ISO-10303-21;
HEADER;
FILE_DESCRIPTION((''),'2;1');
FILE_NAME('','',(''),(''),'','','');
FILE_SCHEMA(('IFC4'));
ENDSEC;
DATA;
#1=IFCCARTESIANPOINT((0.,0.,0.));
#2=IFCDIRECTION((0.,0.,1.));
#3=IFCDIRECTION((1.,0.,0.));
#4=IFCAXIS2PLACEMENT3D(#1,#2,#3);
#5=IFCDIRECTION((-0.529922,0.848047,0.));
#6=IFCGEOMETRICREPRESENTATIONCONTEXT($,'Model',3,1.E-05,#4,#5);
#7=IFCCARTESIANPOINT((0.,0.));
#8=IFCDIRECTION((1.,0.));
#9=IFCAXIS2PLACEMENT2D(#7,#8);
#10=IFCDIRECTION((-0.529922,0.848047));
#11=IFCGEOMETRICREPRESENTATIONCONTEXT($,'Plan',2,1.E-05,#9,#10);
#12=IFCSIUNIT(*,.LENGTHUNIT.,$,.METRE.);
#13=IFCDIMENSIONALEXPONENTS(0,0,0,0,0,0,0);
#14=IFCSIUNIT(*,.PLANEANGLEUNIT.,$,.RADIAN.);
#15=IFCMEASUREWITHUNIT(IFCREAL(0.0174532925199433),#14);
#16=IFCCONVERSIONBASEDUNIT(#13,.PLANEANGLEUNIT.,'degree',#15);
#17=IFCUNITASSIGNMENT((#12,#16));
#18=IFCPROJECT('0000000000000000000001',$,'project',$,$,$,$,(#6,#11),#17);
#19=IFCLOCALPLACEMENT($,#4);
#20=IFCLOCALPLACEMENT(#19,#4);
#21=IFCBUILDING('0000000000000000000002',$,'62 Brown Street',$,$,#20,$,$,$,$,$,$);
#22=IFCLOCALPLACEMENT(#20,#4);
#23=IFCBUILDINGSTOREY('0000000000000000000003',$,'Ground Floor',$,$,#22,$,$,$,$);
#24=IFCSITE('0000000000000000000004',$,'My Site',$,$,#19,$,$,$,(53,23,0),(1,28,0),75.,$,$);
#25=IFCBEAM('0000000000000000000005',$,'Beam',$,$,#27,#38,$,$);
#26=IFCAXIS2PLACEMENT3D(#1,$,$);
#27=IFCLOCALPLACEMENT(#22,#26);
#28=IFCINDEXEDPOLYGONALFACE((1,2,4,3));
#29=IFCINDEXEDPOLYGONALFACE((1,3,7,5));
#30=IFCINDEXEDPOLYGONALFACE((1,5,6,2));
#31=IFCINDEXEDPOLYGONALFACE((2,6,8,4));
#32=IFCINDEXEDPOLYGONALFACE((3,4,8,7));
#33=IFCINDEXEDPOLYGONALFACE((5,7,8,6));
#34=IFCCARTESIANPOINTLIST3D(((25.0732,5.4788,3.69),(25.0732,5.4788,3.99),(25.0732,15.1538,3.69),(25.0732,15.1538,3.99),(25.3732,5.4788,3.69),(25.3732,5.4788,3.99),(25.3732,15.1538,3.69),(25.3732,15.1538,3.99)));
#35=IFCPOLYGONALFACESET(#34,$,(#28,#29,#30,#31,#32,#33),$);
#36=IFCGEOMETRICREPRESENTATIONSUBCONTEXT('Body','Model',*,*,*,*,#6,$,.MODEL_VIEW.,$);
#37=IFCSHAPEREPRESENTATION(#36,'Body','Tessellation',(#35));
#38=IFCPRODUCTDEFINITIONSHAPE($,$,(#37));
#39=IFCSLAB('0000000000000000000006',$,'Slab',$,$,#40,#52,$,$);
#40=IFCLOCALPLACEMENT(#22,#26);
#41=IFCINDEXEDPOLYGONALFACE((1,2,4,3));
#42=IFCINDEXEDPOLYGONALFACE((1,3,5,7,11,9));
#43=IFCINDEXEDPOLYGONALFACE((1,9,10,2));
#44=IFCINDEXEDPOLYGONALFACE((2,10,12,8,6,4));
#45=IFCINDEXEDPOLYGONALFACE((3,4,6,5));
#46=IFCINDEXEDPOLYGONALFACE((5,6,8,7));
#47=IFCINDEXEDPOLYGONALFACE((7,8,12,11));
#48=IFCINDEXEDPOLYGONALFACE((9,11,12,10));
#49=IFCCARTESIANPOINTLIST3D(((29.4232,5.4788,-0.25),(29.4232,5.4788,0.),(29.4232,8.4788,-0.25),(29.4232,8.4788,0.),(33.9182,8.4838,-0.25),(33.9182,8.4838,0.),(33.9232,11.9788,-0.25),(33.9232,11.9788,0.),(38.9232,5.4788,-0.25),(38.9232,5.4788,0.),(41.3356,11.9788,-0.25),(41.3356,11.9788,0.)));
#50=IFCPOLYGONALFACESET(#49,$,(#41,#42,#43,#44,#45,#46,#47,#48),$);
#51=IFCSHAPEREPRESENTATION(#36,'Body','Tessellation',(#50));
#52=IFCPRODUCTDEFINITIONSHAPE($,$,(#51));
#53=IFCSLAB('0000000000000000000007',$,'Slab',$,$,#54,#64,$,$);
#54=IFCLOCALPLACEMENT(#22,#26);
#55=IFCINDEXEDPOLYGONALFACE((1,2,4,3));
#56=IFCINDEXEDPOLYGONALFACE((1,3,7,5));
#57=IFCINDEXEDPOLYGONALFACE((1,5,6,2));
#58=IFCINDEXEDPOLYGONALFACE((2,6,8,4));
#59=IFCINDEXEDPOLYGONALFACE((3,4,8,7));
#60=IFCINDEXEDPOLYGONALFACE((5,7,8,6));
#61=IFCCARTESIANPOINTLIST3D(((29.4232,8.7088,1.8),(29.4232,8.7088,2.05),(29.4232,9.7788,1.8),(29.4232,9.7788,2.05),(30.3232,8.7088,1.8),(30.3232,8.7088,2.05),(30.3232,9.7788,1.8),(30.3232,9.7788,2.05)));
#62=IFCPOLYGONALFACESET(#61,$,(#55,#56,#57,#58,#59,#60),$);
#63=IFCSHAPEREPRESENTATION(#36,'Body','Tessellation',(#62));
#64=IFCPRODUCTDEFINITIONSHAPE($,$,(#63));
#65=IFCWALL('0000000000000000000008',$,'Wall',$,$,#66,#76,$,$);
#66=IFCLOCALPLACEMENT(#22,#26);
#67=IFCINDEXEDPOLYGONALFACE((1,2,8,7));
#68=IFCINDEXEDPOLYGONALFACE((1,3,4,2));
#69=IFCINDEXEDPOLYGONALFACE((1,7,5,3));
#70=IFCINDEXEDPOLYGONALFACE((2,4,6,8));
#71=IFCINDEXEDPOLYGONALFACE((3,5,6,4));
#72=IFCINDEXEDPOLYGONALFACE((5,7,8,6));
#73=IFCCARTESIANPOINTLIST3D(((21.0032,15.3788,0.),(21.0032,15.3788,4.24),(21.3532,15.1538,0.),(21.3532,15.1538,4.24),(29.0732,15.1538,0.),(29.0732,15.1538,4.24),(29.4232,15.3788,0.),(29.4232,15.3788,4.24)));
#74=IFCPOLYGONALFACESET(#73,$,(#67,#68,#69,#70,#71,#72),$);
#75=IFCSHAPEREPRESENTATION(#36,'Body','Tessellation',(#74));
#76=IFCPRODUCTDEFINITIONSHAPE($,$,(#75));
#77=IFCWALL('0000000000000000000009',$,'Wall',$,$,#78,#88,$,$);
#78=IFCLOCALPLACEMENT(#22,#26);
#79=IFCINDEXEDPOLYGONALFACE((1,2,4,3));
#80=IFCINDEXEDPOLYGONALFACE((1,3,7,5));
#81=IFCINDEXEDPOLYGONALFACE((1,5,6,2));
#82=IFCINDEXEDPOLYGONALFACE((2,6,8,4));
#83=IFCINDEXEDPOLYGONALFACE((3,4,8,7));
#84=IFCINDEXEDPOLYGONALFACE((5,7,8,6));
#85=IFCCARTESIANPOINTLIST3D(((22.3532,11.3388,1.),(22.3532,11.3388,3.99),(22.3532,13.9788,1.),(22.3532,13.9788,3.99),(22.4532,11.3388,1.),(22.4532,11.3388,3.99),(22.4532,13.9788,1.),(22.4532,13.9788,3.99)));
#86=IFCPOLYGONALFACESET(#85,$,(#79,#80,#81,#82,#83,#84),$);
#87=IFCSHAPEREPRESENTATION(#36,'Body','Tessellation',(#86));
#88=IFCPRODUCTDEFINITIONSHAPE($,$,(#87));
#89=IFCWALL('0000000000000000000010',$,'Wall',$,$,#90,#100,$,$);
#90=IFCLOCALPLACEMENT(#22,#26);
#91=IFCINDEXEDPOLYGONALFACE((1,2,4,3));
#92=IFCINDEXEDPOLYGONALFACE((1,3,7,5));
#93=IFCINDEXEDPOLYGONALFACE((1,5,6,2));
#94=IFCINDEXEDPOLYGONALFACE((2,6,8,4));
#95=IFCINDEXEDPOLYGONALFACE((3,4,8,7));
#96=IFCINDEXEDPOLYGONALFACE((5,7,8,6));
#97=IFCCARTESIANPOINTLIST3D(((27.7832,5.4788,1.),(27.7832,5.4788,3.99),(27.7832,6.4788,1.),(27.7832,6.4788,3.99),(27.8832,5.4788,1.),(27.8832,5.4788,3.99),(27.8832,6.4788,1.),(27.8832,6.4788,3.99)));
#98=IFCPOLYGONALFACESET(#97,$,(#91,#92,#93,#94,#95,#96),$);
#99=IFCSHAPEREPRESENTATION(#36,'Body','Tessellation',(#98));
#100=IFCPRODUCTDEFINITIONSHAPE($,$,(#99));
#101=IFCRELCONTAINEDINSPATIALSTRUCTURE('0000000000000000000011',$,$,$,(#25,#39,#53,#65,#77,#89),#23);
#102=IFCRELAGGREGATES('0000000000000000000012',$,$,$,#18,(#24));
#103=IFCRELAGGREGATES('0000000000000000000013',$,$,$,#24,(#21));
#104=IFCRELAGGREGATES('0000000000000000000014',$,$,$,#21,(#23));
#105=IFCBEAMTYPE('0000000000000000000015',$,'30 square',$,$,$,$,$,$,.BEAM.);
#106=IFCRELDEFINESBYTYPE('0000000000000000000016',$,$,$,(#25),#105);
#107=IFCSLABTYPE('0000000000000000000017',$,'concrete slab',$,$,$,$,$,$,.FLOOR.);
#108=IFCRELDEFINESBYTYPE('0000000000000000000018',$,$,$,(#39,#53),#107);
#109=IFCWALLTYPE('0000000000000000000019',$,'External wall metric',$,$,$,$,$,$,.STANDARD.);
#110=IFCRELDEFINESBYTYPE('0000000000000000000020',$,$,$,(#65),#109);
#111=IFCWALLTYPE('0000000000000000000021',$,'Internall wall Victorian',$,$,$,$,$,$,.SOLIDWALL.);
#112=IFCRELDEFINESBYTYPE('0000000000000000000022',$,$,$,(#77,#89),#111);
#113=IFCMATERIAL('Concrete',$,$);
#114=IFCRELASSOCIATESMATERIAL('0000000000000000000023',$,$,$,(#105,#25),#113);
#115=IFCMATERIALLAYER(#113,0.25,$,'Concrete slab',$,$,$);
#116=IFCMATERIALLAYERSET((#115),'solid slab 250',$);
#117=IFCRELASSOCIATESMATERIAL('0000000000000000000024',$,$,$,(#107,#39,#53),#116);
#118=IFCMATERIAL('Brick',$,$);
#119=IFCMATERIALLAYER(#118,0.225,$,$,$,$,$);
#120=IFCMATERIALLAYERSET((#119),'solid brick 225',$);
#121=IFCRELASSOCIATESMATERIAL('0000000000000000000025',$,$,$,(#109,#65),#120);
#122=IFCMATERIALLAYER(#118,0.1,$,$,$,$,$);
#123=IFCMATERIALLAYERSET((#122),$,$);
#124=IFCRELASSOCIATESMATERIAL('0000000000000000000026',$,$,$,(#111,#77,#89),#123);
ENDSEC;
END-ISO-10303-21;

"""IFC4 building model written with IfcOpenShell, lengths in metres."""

from ifc_helpers import new_model, entity, si_unit, converted_unit, direction, frame, origin_with_axes, origin_2d_with_axis, place, context, subcontext, project, spatial, line, indexed_curve, rectangle, outline, extrude, clip, halfspace, material, layer, layer_set, layer_usage, material_profile, profile_set, profile_usage, type_object, element, save


model = new_model("IFC4")

# Units and contexts
model_context = context("Model", 3, precision=1e-05, world=origin_with_axes(), true_north=direction((-0.529922, 0.848047, 0.0)))
plan_context = context("Plan", 2, precision=1e-05, world=origin_2d_with_axis(), true_north=direction((-0.529922, 0.848047)))
body_context_1 = subcontext(model_context, "Body", "Model", "MODEL_VIEW")
ifc_project = project(units=[si_unit("LENGTHUNIT", "METRE"), converted_unit("PLANEANGLEUNIT", "degree", entity("IfcReal", 0.0174532925199433), si_unit("PLANEANGLEUNIT", "RADIAN"), dimensions=[0, 0, 0, 0, 0, 0, 0])], contexts=[model_context, plan_context])

# Site, building, storey
site_placement = place(None, origin_with_axes())
site = spatial("IfcSite", under=ifc_project, at=site_placement, Name="My Site", RefLatitude=(53, 23, 0), RefLongitude=(1, 28, 0), RefElevation=75.0)
building_placement = place(site_placement, origin_with_axes())
building = spatial("IfcBuilding", under=site, at=building_placement, Name="62 Brown Street")
storey_placement = place(building_placement, origin_with_axes())
storey = spatial("IfcBuildingStorey", under=building, at=storey_placement, Name="Ground Floor")

# Shared definitions
ifc_material_1 = material(Name="Concrete")

# Beam
ifc_material_profile_1 = material_profile(ifc_material_1, rectangle(XDim=0.3, YDim=0.3))
ifc_profile_set_1 = profile_set([ifc_material_profile_1])
ifc_profile_usage_1 = profile_usage(ifc_profile_set_1, cardinal=5)
beam_type = type_object("IfcBeamType", Name="30 square", PredefinedType="BEAM", material=ifc_profile_set_1)
beam_placement = place(storey_placement, frame((25.2232, 5.4788, 3.84), z_axis=(0.0, 1.0, 0.0), x_axis=(-1.0, 0.0, 0.0)))
element("IfcBeam", 1, at=beam_placement, inside=storey, type_object=beam_type, material=ifc_profile_usage_1, Name="Beam", context=body_context_1, shape_type="SweptSolid", body=[
    extrude(rectangle(XDim=0.3, YDim=0.3), origin_with_axes(), (0.0, 0.0, 1.0), 9.675),
])

# Slabs
ifc_layer_1 = layer(ifc_material_1, 0.25, Name="Concrete slab")
ifc_layer_set_1 = layer_set([ifc_layer_1], Name="solid slab 250")
ifc_layer_usage_1 = layer_usage(ifc_layer_set_1, "AXIS3", "POSITIVE", 0.0)
slab_type = type_object("IfcSlabType", Name="concrete slab", PredefinedType="FLOOR", material=ifc_layer_set_1)
slab_1_placement = place(storey_placement, frame((29.4232, 5.4788, -0.25), z_axis=(0.0, 0.0, 1.0), x_axis=(1.0, 0.0, 0.0)))
element("IfcSlab", 2, at=slab_1_placement, inside=storey, type_object=slab_type, material=ifc_layer_usage_1, Name="Slab", context=body_context_1, shape_type="SweptSolid", body=[
    extrude(outline(indexed_curve([(0.0, 0.0), (9.5, 0.0), (11.9124, 6.5), (0.0, 3.0), (4.5, 6.5), (4.495, 3.005)], segments=[line(1, 2), line(2, 3), line(3, 5), line(5, 6), line(6, 4), line(4, 1)], self_intersect=False)), None, (0.0, 0.0, 1.0), 0.25),
])
ifc_layer_usage_2 = layer_usage(ifc_layer_set_1, "AXIS3", "POSITIVE", 0.0)
slab_2_placement = place(storey_placement, frame((29.4232, 8.7088, 1.8), z_axis=(0.0, 0.0, 1.0), x_axis=(1.0, 0.0, 0.0)))
element("IfcSlab", 3, at=slab_2_placement, inside=storey, type_object=slab_type, material=ifc_layer_usage_2, Name="Slab", context=body_context_1, shape_type="SweptSolid", body=[
    extrude(outline(indexed_curve([(0.9, 1.07), (0.9, 0.0), (0.0, 0.0), (0.0, 1.07)], segments=[line(3, 2), line(2, 1), line(1, 4), line(4, 3)], self_intersect=False)), None, (0.0, 0.0, 1.0), 0.25),
])

# Walls
ifc_material_2 = material(Name="Brick")
ifc_layer_2 = layer(ifc_material_2, 0.225)
ifc_layer_set_2 = layer_set([ifc_layer_2], Name="solid brick 225")
wall_type_1 = type_object("IfcWallType", Name="External wall metric", PredefinedType="STANDARD", material=ifc_layer_set_2)
ifc_layer_usage_3 = layer_usage(ifc_layer_set_2, "AXIS2", "POSITIVE", 0.0)
wall_1_placement = place(storey_placement, frame((29.4232, 15.3788, 0.0), z_axis=(0.0, 0.0, 1.0), x_axis=(-1.0, 0.0, 0.0)))
element("IfcWall", 4, at=wall_1_placement, inside=storey, type_object=wall_type_1, material=ifc_layer_usage_3, Name="Wall", context=body_context_1, shape_type="Clipping", body=[
    clip(clip(extrude(outline(indexed_curve([(0.0, 0.0), (0.0, 0.225), (8.42, 0.225), (8.42, 0.0), (0.0, 0.0)], self_intersect=False)), origin_with_axes(), (0.0, 0.0, 1.0), 4.24), halfspace(frame((8.42, 0.0, 0.0), z_axis=(0.540756, 0.841179, 0.0), x_axis=(-0.841179, 0.540756, 0.0)), False)), halfspace(frame((0.0, 0.0, 0.0), z_axis=(-0.540758, 0.841178, 0.0), x_axis=(0.841178, 0.540758, 0.0)), False)),
])
ifc_layer_3 = layer(ifc_material_2, 0.1)
ifc_layer_set_3 = layer_set([ifc_layer_3])
ifc_layer_usage_4 = layer_usage(ifc_layer_set_3, "AXIS2", "POSITIVE", 0.0)
wall_type_2 = type_object("IfcWallType", Name="Internall wall Victorian", PredefinedType="SOLIDWALL", material=ifc_layer_set_3)
wall_2_placement = place(storey_placement, frame((22.4532, 11.3388, 1.0), z_axis=(0.0, 0.0, 1.0), x_axis=(0.0, 1.0, 0.0)))
element("IfcWall", 5, at=wall_2_placement, inside=storey, type_object=wall_type_2, material=ifc_layer_usage_4, Name="Wall", context=body_context_1, shape_type="SweptSolid", body=[
    extrude(outline(indexed_curve([(0.0, 0.0), (0.0, 0.1), (2.64, 0.1), (2.64, 0.0), (0.0, 0.0)], self_intersect=False)), origin_with_axes(), (0.0, 0.0, 1.0), 2.99),
])
ifc_layer_usage_5 = layer_usage(ifc_layer_set_3, "AXIS2", "POSITIVE", 0.0)
wall_3_placement = place(storey_placement, frame((27.8832, 5.4788, 1.0), z_axis=(0.0, 0.0, 1.0), x_axis=(0.0, 1.0, 0.0)))
element("IfcWall", 6, at=wall_3_placement, inside=storey, type_object=wall_type_2, material=ifc_layer_usage_5, Name="Wall", context=body_context_1, shape_type="SweptSolid", body=[
    extrude(outline(indexed_curve([(0.0, 0.0), (0.0, 0.1), (1.0, 0.1), (1.0, 0.0), (0.0, 0.0)], self_intersect=False)), origin_with_axes(), (0.0, 0.0, 1.0), 2.99),
])

save(model, "model.ifc")
